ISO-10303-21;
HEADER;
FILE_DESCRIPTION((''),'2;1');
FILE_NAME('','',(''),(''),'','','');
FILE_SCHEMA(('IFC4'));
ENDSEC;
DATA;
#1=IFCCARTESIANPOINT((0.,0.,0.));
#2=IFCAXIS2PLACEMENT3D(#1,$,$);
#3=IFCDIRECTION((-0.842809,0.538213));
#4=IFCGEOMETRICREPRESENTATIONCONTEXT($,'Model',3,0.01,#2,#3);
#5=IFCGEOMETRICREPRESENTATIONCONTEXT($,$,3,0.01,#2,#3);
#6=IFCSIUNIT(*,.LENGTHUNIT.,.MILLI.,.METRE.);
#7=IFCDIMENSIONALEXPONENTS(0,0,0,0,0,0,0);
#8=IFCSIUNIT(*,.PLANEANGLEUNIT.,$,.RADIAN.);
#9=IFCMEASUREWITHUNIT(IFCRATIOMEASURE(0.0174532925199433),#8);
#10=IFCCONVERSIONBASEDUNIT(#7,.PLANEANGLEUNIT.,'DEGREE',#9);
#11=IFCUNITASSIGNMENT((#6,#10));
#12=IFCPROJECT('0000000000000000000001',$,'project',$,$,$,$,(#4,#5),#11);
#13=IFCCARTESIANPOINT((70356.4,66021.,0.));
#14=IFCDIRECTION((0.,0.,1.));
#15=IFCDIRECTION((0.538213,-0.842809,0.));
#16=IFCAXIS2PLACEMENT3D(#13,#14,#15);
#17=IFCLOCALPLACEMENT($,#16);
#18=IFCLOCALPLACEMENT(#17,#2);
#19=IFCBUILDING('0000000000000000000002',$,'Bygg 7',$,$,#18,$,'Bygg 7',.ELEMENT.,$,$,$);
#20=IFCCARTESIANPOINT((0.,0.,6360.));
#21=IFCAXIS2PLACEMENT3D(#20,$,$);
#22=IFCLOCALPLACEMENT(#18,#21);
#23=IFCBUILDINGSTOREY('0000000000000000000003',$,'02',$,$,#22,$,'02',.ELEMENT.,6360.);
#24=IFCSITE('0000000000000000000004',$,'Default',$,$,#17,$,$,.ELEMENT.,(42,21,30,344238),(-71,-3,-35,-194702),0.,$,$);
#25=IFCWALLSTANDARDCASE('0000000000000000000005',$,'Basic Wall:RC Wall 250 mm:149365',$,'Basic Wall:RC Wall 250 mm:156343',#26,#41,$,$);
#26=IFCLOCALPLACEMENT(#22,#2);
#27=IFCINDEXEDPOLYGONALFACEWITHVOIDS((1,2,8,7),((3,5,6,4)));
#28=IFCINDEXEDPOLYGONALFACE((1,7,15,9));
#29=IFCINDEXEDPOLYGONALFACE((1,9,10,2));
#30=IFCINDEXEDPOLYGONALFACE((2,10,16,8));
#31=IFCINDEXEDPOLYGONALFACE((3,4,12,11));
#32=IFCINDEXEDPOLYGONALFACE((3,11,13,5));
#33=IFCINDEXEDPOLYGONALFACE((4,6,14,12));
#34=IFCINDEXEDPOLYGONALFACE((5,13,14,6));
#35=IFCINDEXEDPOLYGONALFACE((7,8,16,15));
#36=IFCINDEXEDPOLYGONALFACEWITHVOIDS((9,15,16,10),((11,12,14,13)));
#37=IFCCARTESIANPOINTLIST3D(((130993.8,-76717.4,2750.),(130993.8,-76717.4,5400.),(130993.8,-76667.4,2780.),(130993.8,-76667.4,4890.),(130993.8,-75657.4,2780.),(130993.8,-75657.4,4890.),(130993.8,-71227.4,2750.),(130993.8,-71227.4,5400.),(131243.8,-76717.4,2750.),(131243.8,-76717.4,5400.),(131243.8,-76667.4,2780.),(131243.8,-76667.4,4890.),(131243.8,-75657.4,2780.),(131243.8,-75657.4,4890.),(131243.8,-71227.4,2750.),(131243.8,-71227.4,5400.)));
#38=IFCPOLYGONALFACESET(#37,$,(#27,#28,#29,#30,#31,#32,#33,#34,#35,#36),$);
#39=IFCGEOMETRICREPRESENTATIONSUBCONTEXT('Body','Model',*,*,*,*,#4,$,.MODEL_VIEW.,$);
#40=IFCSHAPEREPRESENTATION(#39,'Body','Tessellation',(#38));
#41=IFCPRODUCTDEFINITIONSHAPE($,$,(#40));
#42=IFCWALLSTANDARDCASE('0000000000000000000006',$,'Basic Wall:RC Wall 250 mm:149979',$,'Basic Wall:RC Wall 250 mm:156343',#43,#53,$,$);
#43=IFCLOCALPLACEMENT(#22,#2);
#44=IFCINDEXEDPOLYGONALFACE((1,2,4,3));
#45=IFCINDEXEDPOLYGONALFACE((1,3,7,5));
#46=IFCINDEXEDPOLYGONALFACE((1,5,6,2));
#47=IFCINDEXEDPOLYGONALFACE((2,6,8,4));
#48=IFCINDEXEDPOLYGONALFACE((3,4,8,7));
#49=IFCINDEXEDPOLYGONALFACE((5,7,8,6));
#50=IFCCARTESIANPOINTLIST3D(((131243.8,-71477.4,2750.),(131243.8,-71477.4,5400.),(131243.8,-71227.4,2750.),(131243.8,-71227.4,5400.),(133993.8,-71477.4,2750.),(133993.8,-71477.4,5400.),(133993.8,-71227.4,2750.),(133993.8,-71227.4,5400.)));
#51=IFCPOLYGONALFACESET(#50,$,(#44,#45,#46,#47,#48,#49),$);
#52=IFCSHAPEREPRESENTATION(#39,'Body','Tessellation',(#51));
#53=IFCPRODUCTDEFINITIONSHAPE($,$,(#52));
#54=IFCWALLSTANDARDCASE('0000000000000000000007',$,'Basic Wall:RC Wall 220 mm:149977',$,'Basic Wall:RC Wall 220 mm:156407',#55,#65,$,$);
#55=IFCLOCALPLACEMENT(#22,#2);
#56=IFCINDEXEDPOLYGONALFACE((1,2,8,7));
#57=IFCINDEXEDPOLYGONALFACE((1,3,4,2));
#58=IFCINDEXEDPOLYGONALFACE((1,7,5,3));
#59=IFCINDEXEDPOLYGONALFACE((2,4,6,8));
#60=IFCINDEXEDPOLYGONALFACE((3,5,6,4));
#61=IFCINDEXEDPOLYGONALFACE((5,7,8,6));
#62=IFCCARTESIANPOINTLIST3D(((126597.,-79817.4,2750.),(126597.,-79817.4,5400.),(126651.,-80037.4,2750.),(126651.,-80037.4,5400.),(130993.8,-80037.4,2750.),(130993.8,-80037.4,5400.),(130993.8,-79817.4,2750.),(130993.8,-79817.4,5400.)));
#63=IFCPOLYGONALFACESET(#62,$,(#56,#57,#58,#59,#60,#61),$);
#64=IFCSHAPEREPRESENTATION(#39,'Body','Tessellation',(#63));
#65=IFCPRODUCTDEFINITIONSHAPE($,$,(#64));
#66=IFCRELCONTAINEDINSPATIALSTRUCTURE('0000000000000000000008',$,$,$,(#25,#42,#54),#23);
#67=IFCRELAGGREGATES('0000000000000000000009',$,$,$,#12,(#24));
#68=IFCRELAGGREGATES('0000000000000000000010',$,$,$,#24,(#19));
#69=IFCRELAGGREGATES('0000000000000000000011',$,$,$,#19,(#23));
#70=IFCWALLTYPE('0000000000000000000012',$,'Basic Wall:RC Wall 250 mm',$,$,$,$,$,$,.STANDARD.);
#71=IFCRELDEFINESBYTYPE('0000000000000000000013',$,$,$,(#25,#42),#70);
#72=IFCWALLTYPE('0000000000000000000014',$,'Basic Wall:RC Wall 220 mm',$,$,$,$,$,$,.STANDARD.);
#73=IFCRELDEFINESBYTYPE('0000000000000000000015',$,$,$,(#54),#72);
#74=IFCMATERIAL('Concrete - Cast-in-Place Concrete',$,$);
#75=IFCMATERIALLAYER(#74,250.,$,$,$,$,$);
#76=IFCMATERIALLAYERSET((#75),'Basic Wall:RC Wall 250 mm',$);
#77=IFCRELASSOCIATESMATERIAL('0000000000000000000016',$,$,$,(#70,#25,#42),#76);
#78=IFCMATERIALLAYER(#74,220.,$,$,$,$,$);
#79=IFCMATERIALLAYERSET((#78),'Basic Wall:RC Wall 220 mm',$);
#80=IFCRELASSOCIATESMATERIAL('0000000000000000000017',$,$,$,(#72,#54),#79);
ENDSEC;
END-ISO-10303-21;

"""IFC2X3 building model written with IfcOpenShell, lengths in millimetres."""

from ifc_helpers import new_model, entity, si_unit, converted_unit, direction, frame, frame_2d, origin, origin_2d_with_axis, place, context, subcontext, project, spatial, polyline, rectangle, extrude, clip, bounded_halfspace, material, layer, layer_set, layer_usage, type_object, element, save


model = new_model("IFC2X3")

# Units and contexts
model_context = context("Model", 3, precision=0.01, world=origin(), true_north=direction((-0.842809, 0.538213)))
context_of_model = context(None, 3, precision=0.01, world=origin(), true_north=direction((-0.842809, 0.538213)))
body_context = subcontext(model_context, "Body", "Model", "MODEL_VIEW")
ifc_project = project(units=[si_unit("LENGTHUNIT", "METRE", prefix="MILLI"), converted_unit("PLANEANGLEUNIT", "DEGREE", entity("IfcRatioMeasure", 0.0174532925199433), si_unit("PLANEANGLEUNIT", "RADIAN"), dimensions=[0, 0, 0, 0, 0, 0, 0])], contexts=[model_context, context_of_model])

# Site, building, storey
site_placement = place(None, frame((70356.4, 66021.0, 0.0), z_axis=(0.0, 0.0, 1.0), x_axis=(0.538213, -0.842809, 0.0)))
site = spatial("IfcSite", under=ifc_project, at=site_placement, Name="Default", CompositionType="ELEMENT", RefLatitude=(42, 21, 30, 344238), RefLongitude=(-71, -3, -35, -194702), RefElevation=0.0)
building_placement = place(site_placement, origin())
building = spatial("IfcBuilding", under=site, at=building_placement, Name="Bygg 7", LongName="Bygg 7", CompositionType="ELEMENT")
storey_placement = place(building_placement, frame((0.0, 0.0, 6360.0)))
storey = spatial("IfcBuildingStorey", under=building, at=storey_placement, Name="02", LongName="02", CompositionType="ELEMENT", Elevation=6360.0)

# Shared definitions
ifc_material_1 = material(Name="Concrete - Cast-in-Place Concrete")

# Wall, opening
ifc_layer_1 = layer(ifc_material_1, 250.0)
ifc_layer_set_1 = layer_set([ifc_layer_1], Name="Basic Wall:RC Wall 250 mm")
wall_type_1 = type_object("IfcWallType", Name="Basic Wall:RC Wall 250 mm", PredefinedType="STANDARD", material=ifc_layer_set_1)
ifc_layer_usage_1 = layer_usage(ifc_layer_set_1, "AXIS2", "NEGATIVE", 125.0)
wall_1_placement = place(storey_placement, frame((131118.8, -76717.4, 2750.0), z_axis=(0.0, 0.0, 1.0), x_axis=(0.0, 1.0, 0.0)))
wall_1 = element("IfcWallStandardCase", 1, at=wall_1_placement, inside=storey, type_object=wall_type_1, material=ifc_layer_usage_1, Name="Basic Wall:RC Wall 250 mm:149365", ObjectType="Basic Wall:RC Wall 250 mm:156343", context=body_context, shape_type="Clipping", body=[
    clip(clip(extrude(rectangle(XDim=5490.0, YDim=250.0, at=frame_2d((2745.0, 0.0), x_axis=(-1.0, 0.0))), origin(), (0.0, 0.0, 1.0), 2650.0), bounded_halfspace(frame((0.0, -125.0, 2650.0), z_axis=(0.0, 0.0, -1.0), x_axis=(-0.99571, -0.092529, 0.0)), True, frame((0.0, -125.0, 2650.0)), polyline([(0.0, 0.0), (5240.1, 0.0), (5490.0, 0.0), (5490.0, 250.0), (0.0, 250.0), (0.0, 0.0)]))), bounded_halfspace(frame((5490.0, -125.0, 0.0), z_axis=(0.0, 0.0, 1.0), x_axis=(0.0, 1.0, 0.0)), True, frame((5490.0, -125.0, 0.0)), polyline([(0.0, 0.0), (0.0, 250.0), (-5490.0, 250.0), (-5490.0, 0.0), (-250.0, 0.0), (0.0, 0.0)]))),
])
opening_1_placement = place(wall_1_placement, origin())
element("IfcOpeningElement", 2, at=opening_1_placement, cuts=wall_1, ObjectType="Opening", context=body_context, shape_type="SweptSolid", body=[
    extrude(rectangle(XDim=2110.0, YDim=1010.0, at=origin_2d_with_axis()), frame((555.0, -125.0, 1085.0), z_axis=(0.0, 1.0, 0.0), x_axis=(0.0, 0.0, -1.0)), (0.0, 0.0, 1.0), 250.0),
])

# Wall
ifc_layer_usage_2 = layer_usage(ifc_layer_set_1, "AXIS2", "NEGATIVE", 125.0)
wall_2_placement = place(storey_placement, frame((131243.8, -71352.4, 2750.0)))
element("IfcWallStandardCase", 3, at=wall_2_placement, inside=storey, type_object=wall_type_1, material=ifc_layer_usage_2, Name="Basic Wall:RC Wall 250 mm:149979", ObjectType="Basic Wall:RC Wall 250 mm:156343", context=body_context, shape_type="Clipping", body=[
    clip(clip(extrude(rectangle(XDim=2750.0, YDim=250.0, at=frame_2d((1375.0, 0.0), x_axis=(-1.0, 0.0))), origin(), (0.0, 0.0, 1.0), 2650.0), bounded_halfspace(frame((0.0, -125.0, 2650.0), z_axis=(0.0, 0.0, -1.0), x_axis=(0.092529, -0.99571, 0.0)), True, frame((0.0, -125.0, 2650.0)), polyline([(0.0, 0.0), (2750.0, 0.0), (2750.0, 250.0), (0.0, 250.0), (0.0, 0.0)]))), bounded_halfspace(frame((2750.0, -125.0, 0.0), z_axis=(0.0, 0.0, 1.0), x_axis=(-1.0, 0.0, 0.0)), True, frame((2750.0, -125.0, 0.0)), polyline([(0.0, 0.0), (0.0, 250.0), (-2750.0, 250.0), (-2750.0, 0.0), (0.0, 0.0)]))),
])

# Wall, opening
ifc_layer_2 = layer(ifc_material_1, 220.0)
ifc_layer_set_2 = layer_set([ifc_layer_2], Name="Basic Wall:RC Wall 220 mm")
wall_type_2 = type_object("IfcWallType", Name="Basic Wall:RC Wall 220 mm", PredefinedType="STANDARD", material=ifc_layer_set_2)
ifc_layer_usage_3 = layer_usage(ifc_layer_set_2, "AXIS2", "NEGATIVE", 110.0)
wall_3_placement = place(storey_placement, frame((126597.0, -79927.4, 2750.0)))
wall_3 = element("IfcWallStandardCase", 4, at=wall_3_placement, inside=storey, type_object=wall_type_2, material=ifc_layer_usage_3, Name="Basic Wall:RC Wall 220 mm:149977", ObjectType="Basic Wall:RC Wall 220 mm:156407", context=body_context, shape_type="Clipping", body=[
    clip(clip(extrude(rectangle(XDim=4396.8, YDim=220.0, at=frame_2d((2198.4, 0.0), x_axis=(-1.0, 0.0))), origin(), (0.0, 0.0, 1.0), 2650.0), bounded_halfspace(frame((4396.8, -110.0, 2650.0), z_axis=(0.0, 0.0, -1.0), x_axis=(0.092529, -0.99571, 0.0)), True, frame((4396.8, -110.0, 2650.0)), polyline([(0.0, 0.0), (0.0, 220.0), (-4396.8, 220.0), (-4342.8, 0.0), (0.0, 0.0)]))), bounded_halfspace(frame((4396.8, 110.0, 0.0), z_axis=(0.0, 0.0, 1.0), x_axis=(-1.0, 0.0, 0.0)), True, frame((4396.8, 110.0, 0.0)), polyline([(0.0, 0.0), (-4396.8, 0.0), (-4342.8, -220.0), (0.0, -220.0), (0.0, 0.0)]))),
])
opening_2_placement = place(wall_3_placement, origin())
element("IfcOpeningElement", 5, at=opening_2_placement, cuts=wall_3, ObjectType="Opening", context=body_context, shape_type="SweptSolid", body=[
    extrude(rectangle(XDim=250.0, YDim=380.5, at=origin_2d_with_axis()), frame((-104.0, 9.4, -7315.9), z_axis=(0.0, 0.0, 1.0), x_axis=(-0.971172, -0.238381, 0.0)), (0.0, 0.0, 1.0), 18915.9),
])

save(model, "model.ifc")
